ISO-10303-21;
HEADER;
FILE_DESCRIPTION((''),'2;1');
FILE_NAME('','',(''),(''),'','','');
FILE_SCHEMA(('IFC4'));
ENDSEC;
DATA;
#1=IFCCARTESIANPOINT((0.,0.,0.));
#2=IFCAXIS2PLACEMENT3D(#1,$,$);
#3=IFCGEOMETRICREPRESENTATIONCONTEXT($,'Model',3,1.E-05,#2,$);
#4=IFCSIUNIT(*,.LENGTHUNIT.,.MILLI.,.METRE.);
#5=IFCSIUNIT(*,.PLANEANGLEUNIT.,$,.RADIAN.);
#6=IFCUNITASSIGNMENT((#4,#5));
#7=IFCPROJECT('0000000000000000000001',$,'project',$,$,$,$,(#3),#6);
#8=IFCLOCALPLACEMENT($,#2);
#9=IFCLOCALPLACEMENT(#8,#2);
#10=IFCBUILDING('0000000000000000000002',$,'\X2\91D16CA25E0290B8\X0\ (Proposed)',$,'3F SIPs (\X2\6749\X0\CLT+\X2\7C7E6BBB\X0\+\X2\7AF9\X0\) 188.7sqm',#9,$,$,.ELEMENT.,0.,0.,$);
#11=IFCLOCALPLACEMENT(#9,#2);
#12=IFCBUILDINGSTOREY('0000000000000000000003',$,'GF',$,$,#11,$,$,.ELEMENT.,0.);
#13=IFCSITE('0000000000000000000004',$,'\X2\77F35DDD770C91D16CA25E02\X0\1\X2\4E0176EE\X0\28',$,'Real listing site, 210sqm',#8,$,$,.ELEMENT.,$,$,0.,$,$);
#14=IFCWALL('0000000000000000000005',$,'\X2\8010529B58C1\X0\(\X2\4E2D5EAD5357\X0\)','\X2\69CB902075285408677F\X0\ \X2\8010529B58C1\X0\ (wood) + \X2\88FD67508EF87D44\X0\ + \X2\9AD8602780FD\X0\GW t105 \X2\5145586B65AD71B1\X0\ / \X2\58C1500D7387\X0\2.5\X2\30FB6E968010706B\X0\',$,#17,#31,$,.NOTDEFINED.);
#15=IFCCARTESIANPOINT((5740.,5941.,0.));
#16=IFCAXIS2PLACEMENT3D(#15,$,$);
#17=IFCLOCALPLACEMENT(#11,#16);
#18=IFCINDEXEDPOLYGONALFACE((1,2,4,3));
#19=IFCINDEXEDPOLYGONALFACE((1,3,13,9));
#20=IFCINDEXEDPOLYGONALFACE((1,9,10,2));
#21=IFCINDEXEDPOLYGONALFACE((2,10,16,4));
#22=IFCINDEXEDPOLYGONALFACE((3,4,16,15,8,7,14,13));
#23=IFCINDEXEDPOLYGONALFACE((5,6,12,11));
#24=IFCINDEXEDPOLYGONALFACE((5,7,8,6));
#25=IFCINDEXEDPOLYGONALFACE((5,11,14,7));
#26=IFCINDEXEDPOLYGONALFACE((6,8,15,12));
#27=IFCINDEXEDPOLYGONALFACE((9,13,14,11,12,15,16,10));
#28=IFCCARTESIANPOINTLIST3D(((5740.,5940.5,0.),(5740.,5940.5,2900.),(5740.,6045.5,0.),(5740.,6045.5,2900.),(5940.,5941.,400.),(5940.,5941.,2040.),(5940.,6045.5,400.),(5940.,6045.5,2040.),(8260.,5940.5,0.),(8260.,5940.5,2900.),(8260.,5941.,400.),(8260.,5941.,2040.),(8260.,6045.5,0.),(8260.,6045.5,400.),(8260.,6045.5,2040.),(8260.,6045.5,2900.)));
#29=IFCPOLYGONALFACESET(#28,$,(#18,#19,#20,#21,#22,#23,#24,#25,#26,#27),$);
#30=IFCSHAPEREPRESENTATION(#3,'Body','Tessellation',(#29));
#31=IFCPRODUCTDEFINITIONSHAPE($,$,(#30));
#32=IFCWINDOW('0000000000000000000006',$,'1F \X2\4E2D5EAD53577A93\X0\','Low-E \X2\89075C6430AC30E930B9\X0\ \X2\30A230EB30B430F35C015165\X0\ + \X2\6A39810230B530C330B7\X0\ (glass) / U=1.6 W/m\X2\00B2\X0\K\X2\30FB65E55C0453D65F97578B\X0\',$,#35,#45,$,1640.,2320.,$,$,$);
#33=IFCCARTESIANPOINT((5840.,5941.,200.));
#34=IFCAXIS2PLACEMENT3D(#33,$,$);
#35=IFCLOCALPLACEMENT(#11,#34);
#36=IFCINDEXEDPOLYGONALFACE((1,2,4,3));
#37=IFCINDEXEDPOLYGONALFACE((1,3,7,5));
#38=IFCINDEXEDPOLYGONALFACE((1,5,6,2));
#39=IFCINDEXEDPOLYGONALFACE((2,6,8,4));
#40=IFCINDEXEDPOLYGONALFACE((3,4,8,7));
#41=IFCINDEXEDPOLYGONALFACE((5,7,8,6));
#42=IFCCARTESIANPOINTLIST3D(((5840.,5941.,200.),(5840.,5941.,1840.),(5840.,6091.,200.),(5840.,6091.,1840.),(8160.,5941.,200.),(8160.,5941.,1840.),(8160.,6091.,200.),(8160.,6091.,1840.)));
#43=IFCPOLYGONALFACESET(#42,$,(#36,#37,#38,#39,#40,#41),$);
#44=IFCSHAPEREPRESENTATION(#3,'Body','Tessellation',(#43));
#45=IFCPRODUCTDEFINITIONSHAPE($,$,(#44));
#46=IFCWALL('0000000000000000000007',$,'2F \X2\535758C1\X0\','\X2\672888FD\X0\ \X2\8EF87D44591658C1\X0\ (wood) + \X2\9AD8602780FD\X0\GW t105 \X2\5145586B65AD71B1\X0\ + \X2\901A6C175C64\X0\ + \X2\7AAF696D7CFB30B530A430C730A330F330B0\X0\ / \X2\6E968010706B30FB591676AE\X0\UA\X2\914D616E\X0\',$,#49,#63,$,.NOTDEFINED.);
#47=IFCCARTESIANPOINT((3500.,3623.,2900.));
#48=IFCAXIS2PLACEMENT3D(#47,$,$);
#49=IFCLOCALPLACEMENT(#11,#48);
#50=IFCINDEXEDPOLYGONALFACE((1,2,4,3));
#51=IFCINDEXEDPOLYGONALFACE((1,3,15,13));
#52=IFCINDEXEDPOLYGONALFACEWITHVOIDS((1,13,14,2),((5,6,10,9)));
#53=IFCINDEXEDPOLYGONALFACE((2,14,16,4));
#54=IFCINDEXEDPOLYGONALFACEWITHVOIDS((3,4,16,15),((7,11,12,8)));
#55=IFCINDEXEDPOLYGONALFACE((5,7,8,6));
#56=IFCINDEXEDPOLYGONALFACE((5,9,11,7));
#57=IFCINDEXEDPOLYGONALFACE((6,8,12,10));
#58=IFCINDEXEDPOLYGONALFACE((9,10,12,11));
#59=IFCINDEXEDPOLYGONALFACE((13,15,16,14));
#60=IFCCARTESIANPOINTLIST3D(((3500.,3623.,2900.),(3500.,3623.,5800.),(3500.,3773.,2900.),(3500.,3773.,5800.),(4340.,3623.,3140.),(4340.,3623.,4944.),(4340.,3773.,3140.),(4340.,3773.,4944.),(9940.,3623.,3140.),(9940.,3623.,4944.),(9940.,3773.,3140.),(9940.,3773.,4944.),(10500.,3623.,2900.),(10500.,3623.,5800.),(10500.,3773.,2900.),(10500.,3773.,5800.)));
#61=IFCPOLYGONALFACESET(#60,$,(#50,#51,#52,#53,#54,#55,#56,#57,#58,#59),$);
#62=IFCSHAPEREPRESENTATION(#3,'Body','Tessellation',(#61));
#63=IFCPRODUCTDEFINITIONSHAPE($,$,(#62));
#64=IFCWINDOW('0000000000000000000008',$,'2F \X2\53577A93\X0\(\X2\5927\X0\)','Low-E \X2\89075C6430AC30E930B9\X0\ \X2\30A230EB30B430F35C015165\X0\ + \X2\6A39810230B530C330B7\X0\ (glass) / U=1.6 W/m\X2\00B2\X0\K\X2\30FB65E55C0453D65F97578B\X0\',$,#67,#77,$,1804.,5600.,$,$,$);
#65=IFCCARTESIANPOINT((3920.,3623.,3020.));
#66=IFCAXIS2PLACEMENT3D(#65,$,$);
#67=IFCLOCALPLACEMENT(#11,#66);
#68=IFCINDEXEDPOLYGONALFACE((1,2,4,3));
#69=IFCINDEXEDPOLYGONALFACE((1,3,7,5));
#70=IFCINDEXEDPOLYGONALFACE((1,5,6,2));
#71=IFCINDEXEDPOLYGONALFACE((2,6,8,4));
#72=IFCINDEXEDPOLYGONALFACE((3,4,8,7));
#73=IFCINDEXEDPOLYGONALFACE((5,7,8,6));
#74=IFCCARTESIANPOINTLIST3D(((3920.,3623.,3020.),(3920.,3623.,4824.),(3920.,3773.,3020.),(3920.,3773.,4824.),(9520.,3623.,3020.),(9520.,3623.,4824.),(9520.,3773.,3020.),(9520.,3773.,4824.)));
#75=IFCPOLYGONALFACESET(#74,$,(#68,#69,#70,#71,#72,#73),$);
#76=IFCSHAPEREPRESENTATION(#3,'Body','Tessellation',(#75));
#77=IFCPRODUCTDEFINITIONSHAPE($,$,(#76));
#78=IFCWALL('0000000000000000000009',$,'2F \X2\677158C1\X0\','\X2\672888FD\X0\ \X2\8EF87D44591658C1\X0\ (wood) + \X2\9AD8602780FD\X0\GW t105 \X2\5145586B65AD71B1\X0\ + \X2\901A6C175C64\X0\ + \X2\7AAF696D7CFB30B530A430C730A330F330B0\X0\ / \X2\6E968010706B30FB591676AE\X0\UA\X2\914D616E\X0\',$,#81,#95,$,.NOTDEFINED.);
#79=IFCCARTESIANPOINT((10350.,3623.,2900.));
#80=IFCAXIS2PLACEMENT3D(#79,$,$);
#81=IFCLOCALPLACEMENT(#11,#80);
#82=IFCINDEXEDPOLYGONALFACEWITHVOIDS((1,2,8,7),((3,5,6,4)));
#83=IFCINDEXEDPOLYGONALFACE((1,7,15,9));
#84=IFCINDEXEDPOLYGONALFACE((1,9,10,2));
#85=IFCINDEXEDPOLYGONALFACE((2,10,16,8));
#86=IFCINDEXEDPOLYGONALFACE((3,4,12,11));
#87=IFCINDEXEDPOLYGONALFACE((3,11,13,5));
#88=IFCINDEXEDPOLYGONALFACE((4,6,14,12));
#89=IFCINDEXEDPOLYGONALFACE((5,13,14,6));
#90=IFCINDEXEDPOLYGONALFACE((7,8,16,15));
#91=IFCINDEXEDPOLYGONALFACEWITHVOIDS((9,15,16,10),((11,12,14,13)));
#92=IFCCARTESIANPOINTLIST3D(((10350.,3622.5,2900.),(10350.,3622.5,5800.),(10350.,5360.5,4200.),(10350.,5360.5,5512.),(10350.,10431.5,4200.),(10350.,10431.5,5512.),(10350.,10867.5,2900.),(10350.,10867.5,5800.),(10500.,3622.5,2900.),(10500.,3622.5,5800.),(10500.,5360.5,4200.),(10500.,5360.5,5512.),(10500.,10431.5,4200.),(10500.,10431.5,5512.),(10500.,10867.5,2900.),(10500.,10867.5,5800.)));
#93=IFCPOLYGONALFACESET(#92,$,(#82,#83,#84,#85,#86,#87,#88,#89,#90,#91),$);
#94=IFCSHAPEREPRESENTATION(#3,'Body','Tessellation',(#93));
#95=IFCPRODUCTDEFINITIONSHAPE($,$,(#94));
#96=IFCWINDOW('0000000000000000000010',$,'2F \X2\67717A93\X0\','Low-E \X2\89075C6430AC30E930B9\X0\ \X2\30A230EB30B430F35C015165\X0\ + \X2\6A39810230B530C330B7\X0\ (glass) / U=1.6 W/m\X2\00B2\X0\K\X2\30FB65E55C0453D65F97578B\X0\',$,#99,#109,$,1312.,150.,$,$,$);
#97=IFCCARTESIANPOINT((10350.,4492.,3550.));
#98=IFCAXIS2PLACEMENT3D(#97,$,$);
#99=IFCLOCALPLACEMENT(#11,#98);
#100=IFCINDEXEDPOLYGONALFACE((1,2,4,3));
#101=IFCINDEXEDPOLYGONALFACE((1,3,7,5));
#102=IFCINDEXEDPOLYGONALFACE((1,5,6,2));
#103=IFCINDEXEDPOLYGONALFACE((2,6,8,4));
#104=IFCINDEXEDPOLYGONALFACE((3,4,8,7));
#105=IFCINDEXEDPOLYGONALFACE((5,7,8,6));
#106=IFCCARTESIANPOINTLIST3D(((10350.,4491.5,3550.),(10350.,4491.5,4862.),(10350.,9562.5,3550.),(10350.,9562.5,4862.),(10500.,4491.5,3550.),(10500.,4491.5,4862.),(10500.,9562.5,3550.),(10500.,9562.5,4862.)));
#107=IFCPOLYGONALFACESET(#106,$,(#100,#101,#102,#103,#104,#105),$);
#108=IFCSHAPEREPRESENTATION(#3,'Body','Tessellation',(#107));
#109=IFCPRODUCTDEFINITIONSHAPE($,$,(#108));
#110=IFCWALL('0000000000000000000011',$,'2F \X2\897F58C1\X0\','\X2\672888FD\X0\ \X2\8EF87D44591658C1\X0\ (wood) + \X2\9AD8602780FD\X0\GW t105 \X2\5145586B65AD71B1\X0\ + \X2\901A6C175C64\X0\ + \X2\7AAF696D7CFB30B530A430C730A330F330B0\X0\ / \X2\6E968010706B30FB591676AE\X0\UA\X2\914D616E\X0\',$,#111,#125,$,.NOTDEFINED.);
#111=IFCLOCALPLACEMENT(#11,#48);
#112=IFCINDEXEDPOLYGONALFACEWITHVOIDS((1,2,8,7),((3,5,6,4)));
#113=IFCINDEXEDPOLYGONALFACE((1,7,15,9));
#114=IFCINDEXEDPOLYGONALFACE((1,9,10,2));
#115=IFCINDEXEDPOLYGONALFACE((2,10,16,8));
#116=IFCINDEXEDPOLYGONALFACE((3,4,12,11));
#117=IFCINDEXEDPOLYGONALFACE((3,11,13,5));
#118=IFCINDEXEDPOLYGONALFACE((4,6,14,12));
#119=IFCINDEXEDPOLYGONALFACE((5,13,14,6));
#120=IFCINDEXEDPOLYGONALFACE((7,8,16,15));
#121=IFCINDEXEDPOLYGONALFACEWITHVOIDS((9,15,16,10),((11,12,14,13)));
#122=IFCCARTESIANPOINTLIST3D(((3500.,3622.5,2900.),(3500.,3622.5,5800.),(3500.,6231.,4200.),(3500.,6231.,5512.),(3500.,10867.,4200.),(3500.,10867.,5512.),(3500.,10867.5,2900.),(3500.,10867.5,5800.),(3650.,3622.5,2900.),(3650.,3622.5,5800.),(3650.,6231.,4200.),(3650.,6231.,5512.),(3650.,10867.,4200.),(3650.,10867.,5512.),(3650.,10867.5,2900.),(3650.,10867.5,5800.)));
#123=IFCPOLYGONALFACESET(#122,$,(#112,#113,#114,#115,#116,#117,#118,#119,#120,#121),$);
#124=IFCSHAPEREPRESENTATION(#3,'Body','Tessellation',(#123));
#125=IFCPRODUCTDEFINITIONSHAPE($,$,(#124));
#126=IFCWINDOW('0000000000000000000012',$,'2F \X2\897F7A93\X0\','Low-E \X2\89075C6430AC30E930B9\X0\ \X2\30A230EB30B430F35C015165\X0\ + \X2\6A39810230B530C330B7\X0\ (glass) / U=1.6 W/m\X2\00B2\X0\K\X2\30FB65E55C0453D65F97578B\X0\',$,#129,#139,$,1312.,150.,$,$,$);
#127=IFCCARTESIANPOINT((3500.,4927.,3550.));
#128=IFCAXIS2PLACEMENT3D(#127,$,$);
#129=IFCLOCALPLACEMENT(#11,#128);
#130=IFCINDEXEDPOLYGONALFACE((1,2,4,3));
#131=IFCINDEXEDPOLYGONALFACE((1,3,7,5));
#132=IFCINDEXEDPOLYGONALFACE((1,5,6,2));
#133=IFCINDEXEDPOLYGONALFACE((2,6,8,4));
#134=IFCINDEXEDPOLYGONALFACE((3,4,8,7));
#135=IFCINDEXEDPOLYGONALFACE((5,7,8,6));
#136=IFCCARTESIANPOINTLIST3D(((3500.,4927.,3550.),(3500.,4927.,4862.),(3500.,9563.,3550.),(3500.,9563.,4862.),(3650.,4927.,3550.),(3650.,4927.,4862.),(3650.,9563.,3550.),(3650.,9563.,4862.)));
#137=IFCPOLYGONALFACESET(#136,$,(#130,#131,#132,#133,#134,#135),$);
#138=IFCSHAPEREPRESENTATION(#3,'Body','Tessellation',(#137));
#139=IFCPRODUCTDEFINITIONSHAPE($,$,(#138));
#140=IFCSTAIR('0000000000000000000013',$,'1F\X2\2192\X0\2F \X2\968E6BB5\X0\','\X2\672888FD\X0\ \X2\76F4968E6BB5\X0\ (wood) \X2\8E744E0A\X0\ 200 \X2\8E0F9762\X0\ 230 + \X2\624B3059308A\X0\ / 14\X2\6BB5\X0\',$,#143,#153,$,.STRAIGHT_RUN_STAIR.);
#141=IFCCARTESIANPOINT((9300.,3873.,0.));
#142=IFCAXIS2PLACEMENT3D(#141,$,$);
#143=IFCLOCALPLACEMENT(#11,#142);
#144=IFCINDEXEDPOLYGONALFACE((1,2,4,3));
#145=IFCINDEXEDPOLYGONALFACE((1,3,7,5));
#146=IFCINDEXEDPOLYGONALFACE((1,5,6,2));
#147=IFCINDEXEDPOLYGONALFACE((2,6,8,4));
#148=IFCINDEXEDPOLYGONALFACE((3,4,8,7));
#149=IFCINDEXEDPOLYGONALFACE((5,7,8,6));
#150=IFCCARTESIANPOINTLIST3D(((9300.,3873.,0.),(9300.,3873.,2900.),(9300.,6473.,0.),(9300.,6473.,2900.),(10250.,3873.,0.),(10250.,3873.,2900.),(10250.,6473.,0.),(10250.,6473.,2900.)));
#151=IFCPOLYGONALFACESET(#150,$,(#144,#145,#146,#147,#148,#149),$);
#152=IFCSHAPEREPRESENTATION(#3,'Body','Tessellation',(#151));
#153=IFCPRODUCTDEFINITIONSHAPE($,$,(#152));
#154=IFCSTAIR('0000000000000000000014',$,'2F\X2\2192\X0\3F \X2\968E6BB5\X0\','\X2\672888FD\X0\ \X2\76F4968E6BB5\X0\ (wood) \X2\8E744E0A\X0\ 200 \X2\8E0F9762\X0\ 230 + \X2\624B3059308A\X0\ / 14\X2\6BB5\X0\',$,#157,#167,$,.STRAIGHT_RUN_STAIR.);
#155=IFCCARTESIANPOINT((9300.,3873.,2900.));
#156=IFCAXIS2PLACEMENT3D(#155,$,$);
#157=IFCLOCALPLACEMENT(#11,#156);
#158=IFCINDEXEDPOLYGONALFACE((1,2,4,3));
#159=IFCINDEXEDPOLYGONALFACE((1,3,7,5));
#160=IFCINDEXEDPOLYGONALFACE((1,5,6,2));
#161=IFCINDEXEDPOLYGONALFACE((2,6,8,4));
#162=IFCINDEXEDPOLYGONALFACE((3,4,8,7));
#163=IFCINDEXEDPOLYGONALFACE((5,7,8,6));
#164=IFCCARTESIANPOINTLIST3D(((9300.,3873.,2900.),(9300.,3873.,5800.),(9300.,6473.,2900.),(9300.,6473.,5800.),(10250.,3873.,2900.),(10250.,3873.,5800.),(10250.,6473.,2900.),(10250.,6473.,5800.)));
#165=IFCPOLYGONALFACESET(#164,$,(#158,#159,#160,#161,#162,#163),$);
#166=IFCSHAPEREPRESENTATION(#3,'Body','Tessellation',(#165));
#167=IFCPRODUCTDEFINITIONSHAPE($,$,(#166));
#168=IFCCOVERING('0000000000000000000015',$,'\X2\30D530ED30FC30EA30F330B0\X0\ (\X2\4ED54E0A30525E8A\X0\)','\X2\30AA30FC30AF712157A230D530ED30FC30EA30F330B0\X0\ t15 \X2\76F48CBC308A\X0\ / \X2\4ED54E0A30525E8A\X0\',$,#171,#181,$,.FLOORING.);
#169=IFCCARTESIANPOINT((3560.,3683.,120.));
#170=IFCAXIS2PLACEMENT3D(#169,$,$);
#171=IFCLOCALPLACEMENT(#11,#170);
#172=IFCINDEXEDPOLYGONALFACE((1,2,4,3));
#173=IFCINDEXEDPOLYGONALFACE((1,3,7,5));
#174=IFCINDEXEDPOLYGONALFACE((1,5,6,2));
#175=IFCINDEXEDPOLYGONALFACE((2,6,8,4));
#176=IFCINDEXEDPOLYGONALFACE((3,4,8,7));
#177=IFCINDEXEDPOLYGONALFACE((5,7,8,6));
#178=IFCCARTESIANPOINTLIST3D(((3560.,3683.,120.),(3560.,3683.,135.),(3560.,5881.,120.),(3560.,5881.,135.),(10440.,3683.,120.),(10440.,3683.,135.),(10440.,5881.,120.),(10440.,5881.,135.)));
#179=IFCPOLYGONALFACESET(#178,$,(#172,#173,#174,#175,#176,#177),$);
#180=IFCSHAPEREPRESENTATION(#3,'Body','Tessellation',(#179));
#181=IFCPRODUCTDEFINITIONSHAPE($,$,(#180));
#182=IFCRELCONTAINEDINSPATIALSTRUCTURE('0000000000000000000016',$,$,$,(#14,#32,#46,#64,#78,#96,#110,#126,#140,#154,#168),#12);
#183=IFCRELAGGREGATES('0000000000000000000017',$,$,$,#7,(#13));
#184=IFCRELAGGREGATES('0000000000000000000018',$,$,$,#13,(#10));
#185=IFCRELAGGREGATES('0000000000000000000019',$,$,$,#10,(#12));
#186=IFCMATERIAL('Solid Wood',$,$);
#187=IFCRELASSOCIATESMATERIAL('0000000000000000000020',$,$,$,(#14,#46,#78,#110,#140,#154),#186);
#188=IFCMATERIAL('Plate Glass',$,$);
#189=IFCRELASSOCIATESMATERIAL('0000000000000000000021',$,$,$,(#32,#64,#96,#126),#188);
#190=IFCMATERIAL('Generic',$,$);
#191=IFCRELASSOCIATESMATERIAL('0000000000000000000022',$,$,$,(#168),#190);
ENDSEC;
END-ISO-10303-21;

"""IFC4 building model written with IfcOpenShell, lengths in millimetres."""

from ifc_helpers import new_model, si_unit, frame, frame_2d, origin, place, context, project, spatial, rectangle, extrude, material, element, fill, save


model = new_model("IFC4")

# Units and contexts
model_context = context("Model", 3, precision=1e-05, world=origin())
ifc_project = project(units=[si_unit("LENGTHUNIT", "METRE", prefix="MILLI"), si_unit("PLANEANGLEUNIT", "RADIAN")], contexts=[model_context])

# Site, building, storey
site_placement = place(None, origin())
site = spatial("IfcSite", under=ifc_project, at=site_placement, Name="石川県金沢市1丁目28", ObjectType="Real listing site, 210sqm", CompositionType="ELEMENT", RefElevation=0.0)
building_placement = place(site_placement, origin())
building = spatial("IfcBuilding", under=site, at=building_placement, Name="金沢市邸 (Proposed)", ObjectType="3F SIPs (杉CLT+籾殻+竹) 188.7sqm", CompositionType="ELEMENT", ElevationOfRefHeight=0.0, ElevationOfTerrain=0.0)
storey_placement = place(building_placement, origin())
storey = spatial("IfcBuildingStorey", under=building, at=storey_placement, Name="GF", CompositionType="ELEMENT", Elevation=0.0)

# Shared definitions
ifc_material_1 = material(Name="Solid Wood")

# Shared definitions
ifc_material_2 = material(Name="Plate Glass")

# Walls, openings, windows
wall_1_placement = place(storey_placement, frame((5740.0, 5941.0, 0.0)))
wall_1 = element("IfcWall", 1, at=wall_1_placement, inside=storey, material=ifc_material_1, Name="耐力壁(中庭南)", Description="構造用合板 耐力壁 (wood) + 製材軸組 + 高性能GW t105 充填断熱 / 壁倍率2.5・準耐火", PredefinedType="NOTDEFINED", context=model_context, shape_type="SweptSolid", body=[
    extrude(rectangle(XDim=2520.0, YDim=105.0, at=frame_2d((1260.0, 52.0))), frame((5740.0, 5941.0, 0.0)), (0.0, 0.0, 1.0), 2900.0),
])
opening_1_placement = place(storey_placement, frame((5840.0, 5941.0, 200.0)))
opening_1 = element("IfcOpeningElement", 2, at=opening_1_placement, cuts=wall_1, PredefinedType="NOTDEFINED", context=model_context, shape_type="SweptSolid", body=[
    extrude(rectangle(XDim=2320.0, YDim=150.0, at=frame_2d((1160.0, 75.0))), frame((5840.0, 5941.0, 200.0)), (0.0, 0.0, 1.0), 1640.0),
])
window_1_placement = place(storey_placement, frame((5840.0, 5941.0, 200.0)))
window_1 = element("IfcWindow", 3, at=window_1_placement, inside=storey, material=ifc_material_2, Name="1F 中庭南窓", Description="Low-E 複層ガラス アルゴン封入 + 樹脂サッシ (glass) / U=1.6 W/m²K・日射取得型", OverallHeight=1640.0, OverallWidth=2320.0, context=model_context, shape_type="SweptSolid", body=[
    extrude(rectangle(XDim=2320.0, YDim=150.0, at=frame_2d((1160.0, 75.0))), frame((5840.0, 5941.0, 200.0)), (0.0, 0.0, 1.0), 1640.0),
])
fill(opening_1, window_1)
wall_2_placement = place(storey_placement, frame((3500.0, 3623.0, 2900.0)))
wall_2 = element("IfcWall", 4, at=wall_2_placement, inside=storey, material=ifc_material_1, Name="2F 南壁", Description="木製 軸組外壁 (wood) + 高性能GW t105 充填断熱 + 通気層 + 窯業系サイディング / 準耐火・外皮UA配慮", PredefinedType="NOTDEFINED", context=model_context, shape_type="SweptSolid", body=[
    extrude(rectangle(XDim=7000.0, YDim=150.0, at=frame_2d((3500.0, 75.0))), frame((3500.0, 3623.0, 2900.0)), (0.0, 0.0, 1.0), 2900.0),
])
opening_2_placement = place(storey_placement, frame((3920.0, 3623.0, 3020.0)))
opening_2 = element("IfcOpeningElement", 5, at=opening_2_placement, cuts=wall_2, PredefinedType="NOTDEFINED", context=model_context, shape_type="SweptSolid", body=[
    extrude(rectangle(XDim=5600.0, YDim=150.0, at=frame_2d((2800.0, 75.0))), frame((3920.0, 3623.0, 3020.0)), (0.0, 0.0, 1.0), 1804.0),
])
window_2_placement = place(storey_placement, frame((3920.0, 3623.0, 3020.0)))
window_2 = element("IfcWindow", 6, at=window_2_placement, inside=storey, material=ifc_material_2, Name="2F 南窓(大)", Description="Low-E 複層ガラス アルゴン封入 + 樹脂サッシ (glass) / U=1.6 W/m²K・日射取得型", OverallHeight=1804.0, OverallWidth=5600.0, context=model_context, shape_type="SweptSolid", body=[
    extrude(rectangle(XDim=5600.0, YDim=150.0, at=frame_2d((2800.0, 75.0))), frame((3920.0, 3623.0, 3020.0)), (0.0, 0.0, 1.0), 1804.0),
])
fill(opening_2, window_2)
wall_3_placement = place(storey_placement, frame((10350.0, 3623.0, 2900.0)))
wall_3 = element("IfcWall", 7, at=wall_3_placement, inside=storey, material=ifc_material_1, Name="2F 東壁", Description="木製 軸組外壁 (wood) + 高性能GW t105 充填断熱 + 通気層 + 窯業系サイディング / 準耐火・外皮UA配慮", PredefinedType="NOTDEFINED", context=model_context, shape_type="SweptSolid", body=[
    extrude(rectangle(XDim=150.0, YDim=7245.0, at=frame_2d((75.0, 3622.0))), frame((10350.0, 3623.0, 2900.0)), (0.0, 0.0, 1.0), 2900.0),
])
opening_3_placement = place(storey_placement, frame((10350.0, 4492.0, 3550.0)))
opening_3 = element("IfcOpeningElement", 8, at=opening_3_placement, cuts=wall_3, PredefinedType="NOTDEFINED", context=model_context, shape_type="SweptSolid", body=[
    extrude(rectangle(XDim=150.0, YDim=5071.0, at=frame_2d((75.0, 2535.0))), frame((10350.0, 4492.0, 3550.0)), (0.0, 0.0, 1.0), 1312.0),
])
window_3_placement = place(storey_placement, frame((10350.0, 4492.0, 3550.0)))
window_3 = element("IfcWindow", 9, at=window_3_placement, inside=storey, material=ifc_material_2, Name="2F 東窓", Description="Low-E 複層ガラス アルゴン封入 + 樹脂サッシ (glass) / U=1.6 W/m²K・日射取得型", OverallHeight=1312.0, OverallWidth=150.0, context=model_context, shape_type="SweptSolid", body=[
    extrude(rectangle(XDim=150.0, YDim=5071.0, at=frame_2d((75.0, 2535.0))), frame((10350.0, 4492.0, 3550.0)), (0.0, 0.0, 1.0), 1312.0),
])
fill(opening_3, window_3)
wall_4_placement = place(storey_placement, frame((3500.0, 3623.0, 2900.0)))
wall_4 = element("IfcWall", 10, at=wall_4_placement, inside=storey, material=ifc_material_1, Name="2F 西壁", Description="木製 軸組外壁 (wood) + 高性能GW t105 充填断熱 + 通気層 + 窯業系サイディング / 準耐火・外皮UA配慮", PredefinedType="NOTDEFINED", context=model_context, shape_type="SweptSolid", body=[
    extrude(rectangle(XDim=150.0, YDim=7245.0, at=frame_2d((75.0, 3622.0))), frame((3500.0, 3623.0, 2900.0)), (0.0, 0.0, 1.0), 2900.0),
])
opening_4_placement = place(storey_placement, frame((3500.0, 4927.0, 3550.0)))
opening_4 = element("IfcOpeningElement", 11, at=opening_4_placement, cuts=wall_4, PredefinedType="NOTDEFINED", context=model_context, shape_type="SweptSolid", body=[
    extrude(rectangle(XDim=150.0, YDim=4636.0, at=frame_2d((75.0, 2318.0))), frame((3500.0, 4927.0, 3550.0)), (0.0, 0.0, 1.0), 1312.0),
])
window_4_placement = place(storey_placement, frame((3500.0, 4927.0, 3550.0)))
window_4 = element("IfcWindow", 12, at=window_4_placement, inside=storey, material=ifc_material_2, Name="2F 西窓", Description="Low-E 複層ガラス アルゴン封入 + 樹脂サッシ (glass) / U=1.6 W/m²K・日射取得型", OverallHeight=1312.0, OverallWidth=150.0, context=model_context, shape_type="SweptSolid", body=[
    extrude(rectangle(XDim=150.0, YDim=4636.0, at=frame_2d((75.0, 2318.0))), frame((3500.0, 4927.0, 3550.0)), (0.0, 0.0, 1.0), 1312.0),
])
fill(opening_4, window_4)

# Stairs
stair_1_placement = place(storey_placement, frame((9300.0, 3873.0, 0.0)))
element("IfcStair", 13, at=stair_1_placement, inside=storey, material=ifc_material_1, Name="1F→2F 階段", Description="木製 直階段 (wood) 蹴上 200 踏面 230 + 手すり / 14段", PredefinedType="STRAIGHT_RUN_STAIR", context=model_context, shape_type="SweptSolid", body=[
    extrude(rectangle(XDim=950.0, YDim=2600.0, at=frame_2d((475.0, 1300.0))), frame((9300.0, 3873.0, 0.0)), (0.0, 0.0, 1.0), 2900.0),
])
stair_2_placement = place(storey_placement, frame((9300.0, 3873.0, 2900.0)))
element("IfcStair", 14, at=stair_2_placement, inside=storey, material=ifc_material_1, Name="2F→3F 階段", Description="木製 直階段 (wood) 蹴上 200 踏面 230 + 手すり / 14段", PredefinedType="STRAIGHT_RUN_STAIR", context=model_context, shape_type="SweptSolid", body=[
    extrude(rectangle(XDim=950.0, YDim=2600.0, at=frame_2d((475.0, 1300.0))), frame((9300.0, 3873.0, 2900.0)), (0.0, 0.0, 1.0), 2900.0),
])

# Covering
ifc_material_3 = material(Name="Generic")
covering_placement = place(storey_placement, frame((3560.0, 3683.0, 120.0)))
element("IfcCovering", 15, at=covering_placement, inside=storey, material=ifc_material_3, Name="フローリング (仕上げ床)", Description="オーク無垢フローリング t15 直貼り / 仕上げ床", PredefinedType="FLOORING", context=model_context, shape_type="SweptSolid", body=[
    extrude(rectangle(XDim=6880.0, YDim=2198.0, at=frame_2d((3440.0, 1099.0))), frame((3560.0, 3683.0, 120.0)), (0.0, 0.0, 1.0), 15.0),
])

save(model, "model.ifc")
